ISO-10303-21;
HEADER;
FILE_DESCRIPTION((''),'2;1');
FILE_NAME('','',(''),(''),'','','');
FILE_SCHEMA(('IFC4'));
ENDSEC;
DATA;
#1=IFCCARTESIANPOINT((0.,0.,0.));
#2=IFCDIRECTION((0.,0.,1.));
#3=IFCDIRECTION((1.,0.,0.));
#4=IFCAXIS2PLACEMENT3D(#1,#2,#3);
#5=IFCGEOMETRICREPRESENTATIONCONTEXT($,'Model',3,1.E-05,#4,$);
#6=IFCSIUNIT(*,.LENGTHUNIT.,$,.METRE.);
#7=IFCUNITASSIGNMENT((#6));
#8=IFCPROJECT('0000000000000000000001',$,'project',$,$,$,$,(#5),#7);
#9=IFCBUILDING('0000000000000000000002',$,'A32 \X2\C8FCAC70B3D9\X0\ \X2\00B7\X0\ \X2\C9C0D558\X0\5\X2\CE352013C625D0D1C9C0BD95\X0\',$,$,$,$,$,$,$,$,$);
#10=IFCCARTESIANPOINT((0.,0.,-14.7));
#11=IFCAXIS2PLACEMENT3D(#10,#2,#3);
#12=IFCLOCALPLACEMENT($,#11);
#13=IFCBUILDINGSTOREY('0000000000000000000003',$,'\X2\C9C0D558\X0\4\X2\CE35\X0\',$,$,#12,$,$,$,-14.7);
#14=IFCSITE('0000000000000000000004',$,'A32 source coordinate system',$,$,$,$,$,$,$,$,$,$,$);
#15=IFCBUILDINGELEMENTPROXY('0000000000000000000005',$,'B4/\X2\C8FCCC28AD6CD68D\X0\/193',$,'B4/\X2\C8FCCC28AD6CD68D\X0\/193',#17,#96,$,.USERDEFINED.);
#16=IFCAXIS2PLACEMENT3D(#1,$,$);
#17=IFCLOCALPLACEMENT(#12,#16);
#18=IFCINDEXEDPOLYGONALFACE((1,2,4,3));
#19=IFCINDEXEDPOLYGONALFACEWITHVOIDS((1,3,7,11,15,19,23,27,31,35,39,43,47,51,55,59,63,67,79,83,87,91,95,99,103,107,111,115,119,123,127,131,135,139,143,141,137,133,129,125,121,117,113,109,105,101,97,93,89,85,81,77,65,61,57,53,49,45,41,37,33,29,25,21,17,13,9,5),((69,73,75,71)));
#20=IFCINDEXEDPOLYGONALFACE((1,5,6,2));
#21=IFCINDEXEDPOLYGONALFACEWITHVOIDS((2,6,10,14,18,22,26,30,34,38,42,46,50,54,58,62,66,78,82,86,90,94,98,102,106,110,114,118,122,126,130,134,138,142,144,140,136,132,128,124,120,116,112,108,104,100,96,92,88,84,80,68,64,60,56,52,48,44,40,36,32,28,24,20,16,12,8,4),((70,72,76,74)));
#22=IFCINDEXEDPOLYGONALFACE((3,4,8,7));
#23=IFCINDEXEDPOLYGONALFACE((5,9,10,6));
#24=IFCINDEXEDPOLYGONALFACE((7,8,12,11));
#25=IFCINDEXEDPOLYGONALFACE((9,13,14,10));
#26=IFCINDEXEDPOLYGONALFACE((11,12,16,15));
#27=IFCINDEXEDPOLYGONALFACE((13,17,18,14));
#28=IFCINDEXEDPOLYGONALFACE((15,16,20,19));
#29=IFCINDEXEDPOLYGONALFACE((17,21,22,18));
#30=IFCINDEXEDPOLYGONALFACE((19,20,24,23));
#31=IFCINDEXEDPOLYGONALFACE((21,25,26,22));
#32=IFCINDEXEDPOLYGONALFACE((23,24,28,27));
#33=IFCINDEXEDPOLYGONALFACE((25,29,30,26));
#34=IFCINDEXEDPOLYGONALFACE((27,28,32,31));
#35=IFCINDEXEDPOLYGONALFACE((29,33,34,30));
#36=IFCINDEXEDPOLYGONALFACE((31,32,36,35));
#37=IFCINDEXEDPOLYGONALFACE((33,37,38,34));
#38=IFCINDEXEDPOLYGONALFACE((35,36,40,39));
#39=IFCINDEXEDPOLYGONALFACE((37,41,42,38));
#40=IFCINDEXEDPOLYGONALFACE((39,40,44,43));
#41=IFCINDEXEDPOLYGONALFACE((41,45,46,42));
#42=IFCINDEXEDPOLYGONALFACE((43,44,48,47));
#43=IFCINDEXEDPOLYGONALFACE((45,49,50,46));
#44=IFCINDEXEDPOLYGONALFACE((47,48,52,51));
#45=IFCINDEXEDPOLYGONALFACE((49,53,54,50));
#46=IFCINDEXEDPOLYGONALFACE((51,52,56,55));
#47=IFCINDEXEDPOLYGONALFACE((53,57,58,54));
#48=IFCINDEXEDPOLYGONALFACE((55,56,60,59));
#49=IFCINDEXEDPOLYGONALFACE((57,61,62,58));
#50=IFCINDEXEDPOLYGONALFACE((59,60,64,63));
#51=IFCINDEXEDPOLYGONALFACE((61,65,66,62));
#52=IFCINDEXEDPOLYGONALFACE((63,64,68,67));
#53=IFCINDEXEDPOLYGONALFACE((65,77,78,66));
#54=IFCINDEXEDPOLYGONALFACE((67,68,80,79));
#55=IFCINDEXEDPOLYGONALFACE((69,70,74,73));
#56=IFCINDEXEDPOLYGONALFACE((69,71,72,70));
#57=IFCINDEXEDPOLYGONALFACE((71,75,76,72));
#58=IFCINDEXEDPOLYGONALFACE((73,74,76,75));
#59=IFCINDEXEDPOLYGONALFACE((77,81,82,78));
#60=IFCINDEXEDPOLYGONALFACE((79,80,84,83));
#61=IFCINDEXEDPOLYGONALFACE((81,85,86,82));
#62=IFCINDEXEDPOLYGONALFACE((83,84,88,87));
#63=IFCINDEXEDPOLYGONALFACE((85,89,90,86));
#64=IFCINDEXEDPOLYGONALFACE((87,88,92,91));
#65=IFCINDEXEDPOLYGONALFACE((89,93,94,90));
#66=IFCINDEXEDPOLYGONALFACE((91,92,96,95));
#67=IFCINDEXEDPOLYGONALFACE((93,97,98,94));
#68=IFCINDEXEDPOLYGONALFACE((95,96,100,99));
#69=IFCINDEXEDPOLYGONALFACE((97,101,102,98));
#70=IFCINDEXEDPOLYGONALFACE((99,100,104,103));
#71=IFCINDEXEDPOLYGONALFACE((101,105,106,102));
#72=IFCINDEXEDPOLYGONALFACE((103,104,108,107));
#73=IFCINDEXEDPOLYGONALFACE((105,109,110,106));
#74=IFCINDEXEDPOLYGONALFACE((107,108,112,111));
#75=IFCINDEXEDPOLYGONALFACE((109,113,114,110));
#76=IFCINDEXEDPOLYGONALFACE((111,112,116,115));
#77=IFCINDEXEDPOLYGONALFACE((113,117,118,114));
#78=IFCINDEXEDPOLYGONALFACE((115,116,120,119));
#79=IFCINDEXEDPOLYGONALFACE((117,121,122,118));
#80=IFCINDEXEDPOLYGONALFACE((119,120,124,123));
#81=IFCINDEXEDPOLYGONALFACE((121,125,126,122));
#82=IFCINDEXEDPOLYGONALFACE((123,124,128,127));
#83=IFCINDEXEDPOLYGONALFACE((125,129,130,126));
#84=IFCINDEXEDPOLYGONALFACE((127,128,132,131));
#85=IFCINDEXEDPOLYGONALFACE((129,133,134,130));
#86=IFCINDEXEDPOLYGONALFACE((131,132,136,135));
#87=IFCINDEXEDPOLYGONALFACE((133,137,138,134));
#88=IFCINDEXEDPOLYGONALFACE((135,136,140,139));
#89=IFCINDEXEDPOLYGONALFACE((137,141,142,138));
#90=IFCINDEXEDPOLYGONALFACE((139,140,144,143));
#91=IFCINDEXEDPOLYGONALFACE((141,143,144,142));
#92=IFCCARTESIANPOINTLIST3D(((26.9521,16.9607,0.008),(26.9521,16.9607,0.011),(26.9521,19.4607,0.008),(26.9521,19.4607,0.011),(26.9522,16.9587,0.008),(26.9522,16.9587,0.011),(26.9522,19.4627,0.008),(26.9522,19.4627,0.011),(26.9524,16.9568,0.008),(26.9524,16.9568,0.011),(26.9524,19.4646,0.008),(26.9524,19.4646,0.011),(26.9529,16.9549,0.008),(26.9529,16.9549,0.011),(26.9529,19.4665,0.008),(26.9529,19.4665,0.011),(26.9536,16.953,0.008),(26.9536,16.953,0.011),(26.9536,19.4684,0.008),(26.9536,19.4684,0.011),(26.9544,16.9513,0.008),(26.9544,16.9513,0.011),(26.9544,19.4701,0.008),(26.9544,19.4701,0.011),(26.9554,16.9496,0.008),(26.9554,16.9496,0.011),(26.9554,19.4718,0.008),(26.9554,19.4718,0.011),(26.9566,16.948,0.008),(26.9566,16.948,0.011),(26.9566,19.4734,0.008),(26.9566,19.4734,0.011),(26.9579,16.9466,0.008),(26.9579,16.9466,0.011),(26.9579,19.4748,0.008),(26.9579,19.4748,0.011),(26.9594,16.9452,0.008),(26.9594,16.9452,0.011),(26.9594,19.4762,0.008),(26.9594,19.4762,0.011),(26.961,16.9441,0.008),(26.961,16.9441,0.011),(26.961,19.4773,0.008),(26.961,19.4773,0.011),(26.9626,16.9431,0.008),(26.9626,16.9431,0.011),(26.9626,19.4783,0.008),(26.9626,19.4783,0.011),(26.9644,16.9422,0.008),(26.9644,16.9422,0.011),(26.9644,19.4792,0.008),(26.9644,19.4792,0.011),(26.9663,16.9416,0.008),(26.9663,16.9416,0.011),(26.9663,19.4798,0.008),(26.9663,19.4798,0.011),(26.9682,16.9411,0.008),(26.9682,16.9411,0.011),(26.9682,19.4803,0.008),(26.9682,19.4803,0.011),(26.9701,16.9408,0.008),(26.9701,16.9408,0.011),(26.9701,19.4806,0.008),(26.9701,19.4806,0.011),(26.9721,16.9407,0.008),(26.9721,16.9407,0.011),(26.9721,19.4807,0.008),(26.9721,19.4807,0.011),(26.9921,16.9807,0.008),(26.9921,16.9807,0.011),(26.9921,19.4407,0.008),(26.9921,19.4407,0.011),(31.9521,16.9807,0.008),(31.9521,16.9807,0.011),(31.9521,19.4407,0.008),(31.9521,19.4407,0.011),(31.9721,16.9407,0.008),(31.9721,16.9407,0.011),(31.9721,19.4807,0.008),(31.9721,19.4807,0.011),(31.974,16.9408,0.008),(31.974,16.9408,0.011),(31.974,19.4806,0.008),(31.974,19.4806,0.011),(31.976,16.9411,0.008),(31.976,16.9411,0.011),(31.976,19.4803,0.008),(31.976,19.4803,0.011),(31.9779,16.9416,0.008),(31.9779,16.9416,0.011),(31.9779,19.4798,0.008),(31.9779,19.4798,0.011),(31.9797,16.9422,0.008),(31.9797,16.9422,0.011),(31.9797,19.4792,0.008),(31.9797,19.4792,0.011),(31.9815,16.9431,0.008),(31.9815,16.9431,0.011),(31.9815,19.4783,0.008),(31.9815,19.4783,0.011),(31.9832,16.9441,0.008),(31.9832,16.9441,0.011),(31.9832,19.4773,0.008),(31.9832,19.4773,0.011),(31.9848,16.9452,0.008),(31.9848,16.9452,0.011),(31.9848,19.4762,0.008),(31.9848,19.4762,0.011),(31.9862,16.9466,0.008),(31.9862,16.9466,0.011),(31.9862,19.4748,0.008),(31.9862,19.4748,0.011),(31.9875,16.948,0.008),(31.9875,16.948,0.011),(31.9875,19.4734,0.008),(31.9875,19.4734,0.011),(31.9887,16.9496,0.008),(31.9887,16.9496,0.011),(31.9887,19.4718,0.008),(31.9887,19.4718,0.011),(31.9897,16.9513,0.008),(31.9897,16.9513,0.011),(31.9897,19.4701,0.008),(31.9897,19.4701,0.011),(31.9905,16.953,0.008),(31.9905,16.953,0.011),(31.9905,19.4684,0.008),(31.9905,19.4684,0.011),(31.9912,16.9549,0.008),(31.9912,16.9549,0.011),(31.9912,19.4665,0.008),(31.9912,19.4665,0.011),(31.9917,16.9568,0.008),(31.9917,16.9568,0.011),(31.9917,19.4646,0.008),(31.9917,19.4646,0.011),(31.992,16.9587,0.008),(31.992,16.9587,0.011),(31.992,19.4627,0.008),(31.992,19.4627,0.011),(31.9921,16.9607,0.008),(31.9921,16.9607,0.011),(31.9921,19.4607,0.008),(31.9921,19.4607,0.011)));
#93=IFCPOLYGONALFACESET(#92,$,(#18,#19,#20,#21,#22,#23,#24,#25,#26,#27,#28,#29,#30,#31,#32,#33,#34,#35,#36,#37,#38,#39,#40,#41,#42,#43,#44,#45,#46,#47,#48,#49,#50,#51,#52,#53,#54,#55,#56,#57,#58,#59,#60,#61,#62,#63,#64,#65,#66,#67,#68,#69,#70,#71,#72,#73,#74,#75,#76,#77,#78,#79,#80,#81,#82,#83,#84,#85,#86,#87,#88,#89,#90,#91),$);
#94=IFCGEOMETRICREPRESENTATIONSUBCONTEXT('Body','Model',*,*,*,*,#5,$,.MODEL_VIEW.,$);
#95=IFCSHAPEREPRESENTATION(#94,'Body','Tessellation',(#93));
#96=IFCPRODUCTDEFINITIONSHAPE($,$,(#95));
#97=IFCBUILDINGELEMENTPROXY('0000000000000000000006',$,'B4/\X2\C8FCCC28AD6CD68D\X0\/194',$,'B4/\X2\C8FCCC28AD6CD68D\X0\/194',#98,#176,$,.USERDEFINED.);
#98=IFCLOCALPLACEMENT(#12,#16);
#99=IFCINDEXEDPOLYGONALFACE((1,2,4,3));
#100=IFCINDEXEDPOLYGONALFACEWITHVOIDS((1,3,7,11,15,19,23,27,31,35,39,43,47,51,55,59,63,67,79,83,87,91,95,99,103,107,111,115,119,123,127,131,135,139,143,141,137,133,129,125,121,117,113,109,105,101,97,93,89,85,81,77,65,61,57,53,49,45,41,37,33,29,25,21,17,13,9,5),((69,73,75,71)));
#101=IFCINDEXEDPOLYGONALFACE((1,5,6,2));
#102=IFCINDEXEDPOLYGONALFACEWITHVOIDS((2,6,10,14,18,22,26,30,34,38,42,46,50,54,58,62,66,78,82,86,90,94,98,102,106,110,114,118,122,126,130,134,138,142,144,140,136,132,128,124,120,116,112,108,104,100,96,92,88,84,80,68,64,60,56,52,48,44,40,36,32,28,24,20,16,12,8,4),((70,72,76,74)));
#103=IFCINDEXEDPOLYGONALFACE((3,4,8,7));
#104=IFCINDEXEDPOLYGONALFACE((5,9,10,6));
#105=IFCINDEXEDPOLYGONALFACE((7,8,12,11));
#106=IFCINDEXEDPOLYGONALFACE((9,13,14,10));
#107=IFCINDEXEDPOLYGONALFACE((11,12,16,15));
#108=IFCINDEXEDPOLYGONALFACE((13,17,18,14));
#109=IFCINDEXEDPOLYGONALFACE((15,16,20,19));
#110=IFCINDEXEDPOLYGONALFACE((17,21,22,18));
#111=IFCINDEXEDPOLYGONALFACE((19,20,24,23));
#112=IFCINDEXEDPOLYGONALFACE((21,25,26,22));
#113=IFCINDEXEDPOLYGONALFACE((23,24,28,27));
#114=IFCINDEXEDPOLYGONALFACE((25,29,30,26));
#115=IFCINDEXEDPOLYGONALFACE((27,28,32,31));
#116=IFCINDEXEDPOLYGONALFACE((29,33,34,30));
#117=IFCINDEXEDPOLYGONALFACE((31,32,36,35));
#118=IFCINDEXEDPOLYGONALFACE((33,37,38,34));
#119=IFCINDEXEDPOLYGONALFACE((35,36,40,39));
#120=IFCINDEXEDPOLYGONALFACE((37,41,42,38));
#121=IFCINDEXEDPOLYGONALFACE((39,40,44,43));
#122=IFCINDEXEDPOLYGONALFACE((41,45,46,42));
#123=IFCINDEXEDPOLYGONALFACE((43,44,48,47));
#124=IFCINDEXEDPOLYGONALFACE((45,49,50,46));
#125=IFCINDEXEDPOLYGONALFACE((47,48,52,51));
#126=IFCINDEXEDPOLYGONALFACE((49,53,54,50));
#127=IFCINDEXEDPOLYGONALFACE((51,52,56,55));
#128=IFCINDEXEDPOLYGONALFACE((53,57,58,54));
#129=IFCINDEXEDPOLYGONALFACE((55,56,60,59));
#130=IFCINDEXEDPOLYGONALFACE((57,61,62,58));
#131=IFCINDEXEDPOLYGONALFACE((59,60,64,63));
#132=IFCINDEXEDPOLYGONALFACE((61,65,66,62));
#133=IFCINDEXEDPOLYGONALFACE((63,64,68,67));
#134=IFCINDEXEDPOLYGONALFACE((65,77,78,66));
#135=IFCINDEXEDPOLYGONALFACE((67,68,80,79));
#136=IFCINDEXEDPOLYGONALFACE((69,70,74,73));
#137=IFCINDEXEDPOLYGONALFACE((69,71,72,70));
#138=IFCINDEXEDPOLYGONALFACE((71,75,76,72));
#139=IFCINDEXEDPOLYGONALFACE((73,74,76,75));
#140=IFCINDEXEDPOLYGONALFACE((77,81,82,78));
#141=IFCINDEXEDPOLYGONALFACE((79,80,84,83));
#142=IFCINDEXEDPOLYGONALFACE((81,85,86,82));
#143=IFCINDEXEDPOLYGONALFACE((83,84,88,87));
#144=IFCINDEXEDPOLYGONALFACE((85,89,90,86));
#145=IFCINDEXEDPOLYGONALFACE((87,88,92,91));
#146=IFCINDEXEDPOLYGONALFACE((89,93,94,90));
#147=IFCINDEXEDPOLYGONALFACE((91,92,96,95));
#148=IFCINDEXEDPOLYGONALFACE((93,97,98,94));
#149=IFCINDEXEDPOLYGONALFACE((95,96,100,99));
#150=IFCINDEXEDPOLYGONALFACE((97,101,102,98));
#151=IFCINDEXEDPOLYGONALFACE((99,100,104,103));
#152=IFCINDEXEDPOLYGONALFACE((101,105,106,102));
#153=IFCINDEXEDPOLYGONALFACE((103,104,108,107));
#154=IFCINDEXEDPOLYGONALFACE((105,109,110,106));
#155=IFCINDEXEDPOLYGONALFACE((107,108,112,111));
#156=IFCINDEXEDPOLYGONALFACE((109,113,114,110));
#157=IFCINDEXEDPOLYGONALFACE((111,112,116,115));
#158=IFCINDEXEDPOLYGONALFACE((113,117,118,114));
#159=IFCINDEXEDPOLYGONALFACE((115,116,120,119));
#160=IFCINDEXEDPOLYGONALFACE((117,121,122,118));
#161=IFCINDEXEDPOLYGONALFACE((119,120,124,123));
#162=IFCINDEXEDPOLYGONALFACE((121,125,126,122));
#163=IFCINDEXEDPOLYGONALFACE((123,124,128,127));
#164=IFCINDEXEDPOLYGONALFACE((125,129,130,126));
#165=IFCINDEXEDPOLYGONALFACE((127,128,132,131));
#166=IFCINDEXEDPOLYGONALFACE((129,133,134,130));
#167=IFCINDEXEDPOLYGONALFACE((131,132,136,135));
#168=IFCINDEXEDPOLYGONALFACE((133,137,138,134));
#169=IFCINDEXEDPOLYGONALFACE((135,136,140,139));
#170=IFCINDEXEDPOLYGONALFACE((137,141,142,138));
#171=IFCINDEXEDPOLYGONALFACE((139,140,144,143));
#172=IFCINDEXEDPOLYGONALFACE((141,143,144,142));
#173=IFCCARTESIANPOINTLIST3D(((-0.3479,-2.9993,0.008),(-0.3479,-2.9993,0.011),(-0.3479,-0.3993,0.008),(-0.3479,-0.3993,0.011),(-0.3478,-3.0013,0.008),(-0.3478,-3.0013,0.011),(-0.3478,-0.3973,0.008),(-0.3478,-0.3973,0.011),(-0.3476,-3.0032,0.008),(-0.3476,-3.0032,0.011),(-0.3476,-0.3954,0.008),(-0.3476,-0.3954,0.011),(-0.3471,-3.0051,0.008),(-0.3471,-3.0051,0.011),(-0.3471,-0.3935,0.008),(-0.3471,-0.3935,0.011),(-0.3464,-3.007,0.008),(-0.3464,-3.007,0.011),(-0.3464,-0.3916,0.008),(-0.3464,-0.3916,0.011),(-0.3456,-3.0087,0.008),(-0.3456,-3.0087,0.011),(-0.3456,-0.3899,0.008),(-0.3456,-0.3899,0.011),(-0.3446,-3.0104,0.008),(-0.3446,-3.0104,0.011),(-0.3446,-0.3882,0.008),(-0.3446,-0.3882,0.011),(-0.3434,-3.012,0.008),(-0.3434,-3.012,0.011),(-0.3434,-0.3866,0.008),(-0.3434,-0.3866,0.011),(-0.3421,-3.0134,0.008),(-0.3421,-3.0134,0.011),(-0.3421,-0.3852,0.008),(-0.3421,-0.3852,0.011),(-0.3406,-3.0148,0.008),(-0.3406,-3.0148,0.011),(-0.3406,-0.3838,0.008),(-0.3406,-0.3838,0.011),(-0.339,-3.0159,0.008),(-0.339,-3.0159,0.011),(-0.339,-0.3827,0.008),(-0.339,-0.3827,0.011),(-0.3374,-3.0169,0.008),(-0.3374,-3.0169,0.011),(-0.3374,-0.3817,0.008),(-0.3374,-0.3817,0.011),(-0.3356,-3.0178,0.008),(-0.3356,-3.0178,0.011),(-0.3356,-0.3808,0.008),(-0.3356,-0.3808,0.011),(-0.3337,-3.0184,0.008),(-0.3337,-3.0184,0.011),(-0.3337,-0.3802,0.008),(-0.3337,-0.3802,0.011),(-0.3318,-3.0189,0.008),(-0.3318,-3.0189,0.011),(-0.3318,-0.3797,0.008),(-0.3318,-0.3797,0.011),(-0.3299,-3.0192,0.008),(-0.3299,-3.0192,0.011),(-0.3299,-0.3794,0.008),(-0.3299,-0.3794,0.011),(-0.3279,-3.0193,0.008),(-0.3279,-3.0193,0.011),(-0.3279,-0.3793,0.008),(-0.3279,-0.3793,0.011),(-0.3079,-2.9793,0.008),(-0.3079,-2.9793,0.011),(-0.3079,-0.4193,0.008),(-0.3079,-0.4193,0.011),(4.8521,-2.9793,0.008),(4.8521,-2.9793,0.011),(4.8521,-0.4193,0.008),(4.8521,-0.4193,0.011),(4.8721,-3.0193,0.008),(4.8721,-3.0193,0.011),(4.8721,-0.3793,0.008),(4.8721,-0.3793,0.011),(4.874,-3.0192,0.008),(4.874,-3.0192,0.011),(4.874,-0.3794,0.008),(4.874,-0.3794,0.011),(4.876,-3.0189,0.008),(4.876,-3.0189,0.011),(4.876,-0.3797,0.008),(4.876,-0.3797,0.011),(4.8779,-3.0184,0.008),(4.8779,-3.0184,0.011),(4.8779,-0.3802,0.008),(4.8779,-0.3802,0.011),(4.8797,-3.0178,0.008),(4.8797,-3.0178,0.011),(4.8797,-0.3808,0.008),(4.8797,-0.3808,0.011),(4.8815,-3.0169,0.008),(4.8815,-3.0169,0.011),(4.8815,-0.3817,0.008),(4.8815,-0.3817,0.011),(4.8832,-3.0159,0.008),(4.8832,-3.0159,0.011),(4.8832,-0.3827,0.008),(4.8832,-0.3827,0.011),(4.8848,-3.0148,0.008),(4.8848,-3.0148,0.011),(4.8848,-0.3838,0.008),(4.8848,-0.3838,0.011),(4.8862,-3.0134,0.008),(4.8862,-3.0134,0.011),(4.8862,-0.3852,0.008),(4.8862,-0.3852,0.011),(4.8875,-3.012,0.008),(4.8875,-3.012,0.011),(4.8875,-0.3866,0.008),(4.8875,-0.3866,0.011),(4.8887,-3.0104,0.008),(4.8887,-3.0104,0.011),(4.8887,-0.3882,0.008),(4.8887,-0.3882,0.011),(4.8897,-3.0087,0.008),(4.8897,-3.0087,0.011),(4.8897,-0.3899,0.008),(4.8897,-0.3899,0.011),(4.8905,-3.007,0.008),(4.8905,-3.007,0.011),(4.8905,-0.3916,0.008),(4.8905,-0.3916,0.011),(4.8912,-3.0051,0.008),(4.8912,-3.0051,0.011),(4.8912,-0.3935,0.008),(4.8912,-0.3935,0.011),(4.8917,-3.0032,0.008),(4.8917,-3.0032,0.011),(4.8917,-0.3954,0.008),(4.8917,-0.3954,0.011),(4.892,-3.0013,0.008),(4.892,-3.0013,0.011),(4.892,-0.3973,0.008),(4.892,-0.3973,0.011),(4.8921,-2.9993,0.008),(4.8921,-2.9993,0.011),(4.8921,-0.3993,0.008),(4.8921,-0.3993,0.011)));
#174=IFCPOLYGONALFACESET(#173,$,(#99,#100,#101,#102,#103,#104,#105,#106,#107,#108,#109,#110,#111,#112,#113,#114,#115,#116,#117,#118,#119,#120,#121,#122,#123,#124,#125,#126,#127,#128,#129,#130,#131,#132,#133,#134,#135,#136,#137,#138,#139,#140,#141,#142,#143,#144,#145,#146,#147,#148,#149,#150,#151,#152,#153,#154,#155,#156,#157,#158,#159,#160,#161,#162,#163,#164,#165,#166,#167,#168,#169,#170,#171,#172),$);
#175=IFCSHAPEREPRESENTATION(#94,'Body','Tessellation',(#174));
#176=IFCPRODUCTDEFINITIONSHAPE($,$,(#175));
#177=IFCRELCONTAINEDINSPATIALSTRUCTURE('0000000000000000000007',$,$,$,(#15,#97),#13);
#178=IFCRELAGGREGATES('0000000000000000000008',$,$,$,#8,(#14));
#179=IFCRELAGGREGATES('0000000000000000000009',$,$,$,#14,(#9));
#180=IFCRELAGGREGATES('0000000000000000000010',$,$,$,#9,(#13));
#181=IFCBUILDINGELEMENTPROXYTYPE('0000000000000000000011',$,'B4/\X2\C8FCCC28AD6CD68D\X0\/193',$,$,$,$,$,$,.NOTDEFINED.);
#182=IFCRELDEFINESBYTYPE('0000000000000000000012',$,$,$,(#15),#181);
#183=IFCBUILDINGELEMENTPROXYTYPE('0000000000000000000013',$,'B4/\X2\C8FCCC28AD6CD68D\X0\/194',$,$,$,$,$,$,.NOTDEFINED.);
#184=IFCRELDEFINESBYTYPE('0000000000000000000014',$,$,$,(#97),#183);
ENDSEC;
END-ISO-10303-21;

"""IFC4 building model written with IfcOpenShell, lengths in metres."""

from ifc_helpers import new_model, si_unit, frame, origin, origin_with_axes, place, context, subcontext, project, spatial, polyline, outline, extrude, source, transform, mapped, type_object, type_shapes, element, save


model = new_model("IFC4")

# Units and contexts
model_context = context("Model", 3, precision=1e-05, world=origin_with_axes())
body_context = subcontext(model_context, "Body", "Model", "MODEL_VIEW")
ifc_project = project(units=[si_unit("LENGTHUNIT", "METRE")], contexts=[model_context])

# Site, building, storey
site = spatial("IfcSite", under=ifc_project, Name="A32 source coordinate system")
building = spatial("IfcBuilding", under=site, Name="A32 주거동 · 지하5층–옥탑지붕")
storey_placement = place(None, frame((0.0, 0.0, -14.7), z_axis=(0.0, 0.0, 1.0), x_axis=(1.0, 0.0, 0.0)))
storey = spatial("IfcBuildingStorey", under=building, at=storey_placement, Name="지하4층", Elevation=-14.7)

# Building element proxies
building_element_proxy_type_1 = type_object("IfcBuildingElementProxyType", Name="B4/주차구획/193", PredefinedType="NOTDEFINED")
shared_shape_1 = source(origin(), body_context, "Body", "SweptSolid", [
    extrude(outline(polyline([(26.9721, 16.9407), (26.9701, 16.9408), (26.9682, 16.9411), (26.9663, 16.9416), (26.9644, 16.9422), (26.9626, 16.9431), (26.961, 16.9441), (26.9594, 16.9452), (26.9579, 16.9466), (26.9566, 16.948), (26.9554, 16.9496), (26.9544, 16.9513), (26.9536, 16.953), (26.9529, 16.9549), (26.9524, 16.9568), (26.9522, 16.9587), (26.9521, 16.9607), (26.9521, 19.4607), (26.9522, 19.4627), (26.9524, 19.4646), (26.9529, 19.4665), (26.9536, 19.4684), (26.9544, 19.4701), (26.9554, 19.4718), (26.9566, 19.4734), (26.9579, 19.4748), (26.9594, 19.4762), (26.961, 19.4773), (26.9626, 19.4783), (26.9644, 19.4792), (26.9663, 19.4798), (26.9682, 19.4803), (26.9701, 19.4806), (26.9721, 19.4807), (31.9721, 19.4807), (31.974, 19.4806), (31.976, 19.4803), (31.9779, 19.4798), (31.9797, 19.4792), (31.9815, 19.4783), (31.9832, 19.4773), (31.9848, 19.4762), (31.9862, 19.4748), (31.9875, 19.4734), (31.9887, 19.4718), (31.9897, 19.4701), (31.9905, 19.4684), (31.9912, 19.4665), (31.9917, 19.4646), (31.992, 19.4627), (31.9921, 19.4607), (31.9921, 16.9607), (31.992, 16.9587), (31.9917, 16.9568), (31.9912, 16.9549), (31.9905, 16.953), (31.9897, 16.9513), (31.9887, 16.9496), (31.9875, 16.948), (31.9862, 16.9466), (31.9848, 16.9452), (31.9832, 16.9441), (31.9815, 16.9431), (31.9797, 16.9422), (31.9779, 16.9416), (31.976, 16.9411), (31.974, 16.9408), (31.9721, 16.9407), (26.9721, 16.9407)]), holes=[polyline([(26.9921, 16.9807), (31.9521, 16.9807), (31.9521, 19.4407), (26.9921, 19.4407), (26.9921, 16.9807)])]), frame((0.0, 0.0, 0.008)), (0.0, 0.0, 1.0), 0.003),
])
type_shapes(building_element_proxy_type_1, [shared_shape_1])
proxy_1_placement = place(storey_placement, origin_with_axes())
element("IfcBuildingElementProxy", 1, at=proxy_1_placement, inside=storey, type_object=building_element_proxy_type_1, Name="B4/주차구획/193", ObjectType="B4/주차구획/193", PredefinedType="USERDEFINED", context=body_context, shape_type="MappedRepresentation", body=[
    mapped(shared_shape_1, transform((0.0, 0.0, 0.0), scale=1.0)),
])
building_element_proxy_type_2 = type_object("IfcBuildingElementProxyType", Name="B4/주차구획/194", PredefinedType="NOTDEFINED")
shared_shape_2 = source(origin(), body_context, "Body", "SweptSolid", [
    extrude(outline(polyline([(-0.3279, -3.0193), (-0.3299, -3.0192), (-0.3318, -3.0189), (-0.3337, -3.0184), (-0.3356, -3.0178), (-0.3374, -3.0169), (-0.339, -3.0159), (-0.3406, -3.0148), (-0.3421, -3.0134), (-0.3434, -3.012), (-0.3446, -3.0104), (-0.3456, -3.0087), (-0.3464, -3.007), (-0.3471, -3.0051), (-0.3476, -3.0032), (-0.3478, -3.0013), (-0.3479, -2.9993), (-0.3479, -0.3993), (-0.3478, -0.3973), (-0.3476, -0.3954), (-0.3471, -0.3935), (-0.3464, -0.3916), (-0.3456, -0.3899), (-0.3446, -0.3882), (-0.3434, -0.3866), (-0.3421, -0.3852), (-0.3406, -0.3838), (-0.339, -0.3827), (-0.3374, -0.3817), (-0.3356, -0.3808), (-0.3337, -0.3802), (-0.3318, -0.3797), (-0.3299, -0.3794), (-0.3279, -0.3793), (4.8721, -0.3793), (4.874, -0.3794), (4.876, -0.3797), (4.8779, -0.3802), (4.8797, -0.3808), (4.8815, -0.3817), (4.8832, -0.3827), (4.8848, -0.3838), (4.8862, -0.3852), (4.8875, -0.3866), (4.8887, -0.3882), (4.8897, -0.3899), (4.8905, -0.3916), (4.8912, -0.3935), (4.8917, -0.3954), (4.892, -0.3973), (4.8921, -0.3993), (4.8921, -2.9993), (4.892, -3.0013), (4.8917, -3.0032), (4.8912, -3.0051), (4.8905, -3.007), (4.8897, -3.0087), (4.8887, -3.0104), (4.8875, -3.012), (4.8862, -3.0134), (4.8848, -3.0148), (4.8832, -3.0159), (4.8815, -3.0169), (4.8797, -3.0178), (4.8779, -3.0184), (4.876, -3.0189), (4.874, -3.0192), (4.8721, -3.0193), (-0.3279, -3.0193)]), holes=[polyline([(-0.3079, -2.9793), (4.8521, -2.9793), (4.8521, -0.4193), (-0.3079, -0.4193), (-0.3079, -2.9793)])]), frame((0.0, 0.0, 0.008)), (0.0, 0.0, 1.0), 0.003),
])
type_shapes(building_element_proxy_type_2, [shared_shape_2])
proxy_2_placement = place(storey_placement, origin_with_axes())
element("IfcBuildingElementProxy", 2, at=proxy_2_placement, inside=storey, type_object=building_element_proxy_type_2, Name="B4/주차구획/194", ObjectType="B4/주차구획/194", PredefinedType="USERDEFINED", context=body_context, shape_type="MappedRepresentation", body=[
    mapped(shared_shape_2, transform((0.0, 0.0, 0.0), scale=1.0)),
])

save(model, "model.ifc")
